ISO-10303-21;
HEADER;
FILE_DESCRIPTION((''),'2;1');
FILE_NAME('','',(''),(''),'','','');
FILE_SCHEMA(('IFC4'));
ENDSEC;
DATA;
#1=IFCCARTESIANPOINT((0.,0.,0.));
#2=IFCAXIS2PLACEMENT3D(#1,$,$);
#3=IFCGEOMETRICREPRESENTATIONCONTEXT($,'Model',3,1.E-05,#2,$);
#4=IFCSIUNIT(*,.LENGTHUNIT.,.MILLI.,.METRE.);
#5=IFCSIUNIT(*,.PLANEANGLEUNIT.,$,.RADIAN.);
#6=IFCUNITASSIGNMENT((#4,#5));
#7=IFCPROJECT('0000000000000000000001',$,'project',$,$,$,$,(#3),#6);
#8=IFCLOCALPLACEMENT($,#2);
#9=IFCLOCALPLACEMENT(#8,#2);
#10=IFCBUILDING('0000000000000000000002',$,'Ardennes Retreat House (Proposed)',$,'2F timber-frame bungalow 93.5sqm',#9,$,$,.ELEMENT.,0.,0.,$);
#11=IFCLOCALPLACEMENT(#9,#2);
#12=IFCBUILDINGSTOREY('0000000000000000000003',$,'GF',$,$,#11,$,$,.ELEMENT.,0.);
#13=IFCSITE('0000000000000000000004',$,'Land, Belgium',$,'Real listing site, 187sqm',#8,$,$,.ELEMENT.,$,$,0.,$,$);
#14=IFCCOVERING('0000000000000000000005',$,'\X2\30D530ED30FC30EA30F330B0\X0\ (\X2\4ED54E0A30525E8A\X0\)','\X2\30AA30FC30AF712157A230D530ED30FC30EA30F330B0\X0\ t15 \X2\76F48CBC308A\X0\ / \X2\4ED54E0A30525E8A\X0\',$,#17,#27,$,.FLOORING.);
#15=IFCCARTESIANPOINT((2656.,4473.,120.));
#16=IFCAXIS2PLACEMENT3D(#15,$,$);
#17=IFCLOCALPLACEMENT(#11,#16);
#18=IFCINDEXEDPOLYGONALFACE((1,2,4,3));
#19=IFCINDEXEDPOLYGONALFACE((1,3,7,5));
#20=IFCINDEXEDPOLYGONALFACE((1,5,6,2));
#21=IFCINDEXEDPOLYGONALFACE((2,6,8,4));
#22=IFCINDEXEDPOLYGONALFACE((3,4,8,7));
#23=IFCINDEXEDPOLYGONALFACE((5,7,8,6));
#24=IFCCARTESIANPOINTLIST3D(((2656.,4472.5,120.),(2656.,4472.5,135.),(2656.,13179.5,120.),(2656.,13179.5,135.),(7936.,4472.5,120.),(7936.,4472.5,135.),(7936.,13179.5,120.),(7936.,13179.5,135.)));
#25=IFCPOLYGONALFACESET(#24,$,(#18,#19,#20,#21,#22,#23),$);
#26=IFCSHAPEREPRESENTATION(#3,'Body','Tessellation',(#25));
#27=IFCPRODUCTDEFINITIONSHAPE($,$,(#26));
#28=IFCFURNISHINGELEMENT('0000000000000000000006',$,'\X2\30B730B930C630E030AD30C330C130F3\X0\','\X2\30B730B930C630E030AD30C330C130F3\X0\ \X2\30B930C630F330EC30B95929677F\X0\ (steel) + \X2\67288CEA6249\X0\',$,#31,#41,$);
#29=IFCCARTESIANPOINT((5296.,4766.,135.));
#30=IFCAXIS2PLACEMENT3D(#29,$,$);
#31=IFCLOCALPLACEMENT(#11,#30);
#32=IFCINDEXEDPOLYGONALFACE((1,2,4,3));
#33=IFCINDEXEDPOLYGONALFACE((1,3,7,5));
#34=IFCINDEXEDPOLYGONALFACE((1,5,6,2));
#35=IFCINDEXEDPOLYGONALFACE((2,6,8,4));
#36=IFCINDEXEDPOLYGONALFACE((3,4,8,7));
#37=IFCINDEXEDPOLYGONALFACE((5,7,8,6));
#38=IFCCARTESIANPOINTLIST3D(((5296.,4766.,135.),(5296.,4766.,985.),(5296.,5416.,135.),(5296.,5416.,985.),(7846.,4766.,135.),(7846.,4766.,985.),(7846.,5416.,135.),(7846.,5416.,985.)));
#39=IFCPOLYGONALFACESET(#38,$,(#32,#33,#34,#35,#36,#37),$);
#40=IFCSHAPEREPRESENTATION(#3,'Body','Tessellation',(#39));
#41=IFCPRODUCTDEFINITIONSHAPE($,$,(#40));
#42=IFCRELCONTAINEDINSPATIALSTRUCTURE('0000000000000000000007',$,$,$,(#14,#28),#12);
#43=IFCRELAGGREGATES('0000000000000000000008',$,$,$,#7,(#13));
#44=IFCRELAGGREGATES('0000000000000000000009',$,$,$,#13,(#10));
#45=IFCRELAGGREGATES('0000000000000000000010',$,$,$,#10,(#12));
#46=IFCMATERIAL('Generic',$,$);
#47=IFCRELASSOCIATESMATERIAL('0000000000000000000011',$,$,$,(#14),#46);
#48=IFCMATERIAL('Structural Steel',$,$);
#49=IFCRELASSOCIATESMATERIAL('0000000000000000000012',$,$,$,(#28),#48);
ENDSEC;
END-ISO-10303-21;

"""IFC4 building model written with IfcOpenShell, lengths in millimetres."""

from ifc_helpers import new_model, si_unit, frame, frame_2d, origin, place, context, project, spatial, rectangle, extrude, material, element, save


model = new_model("IFC4")

# Units and contexts
model_context = context("Model", 3, precision=1e-05, world=origin())
ifc_project = project(units=[si_unit("LENGTHUNIT", "METRE", prefix="MILLI"), si_unit("PLANEANGLEUNIT", "RADIAN")], contexts=[model_context])

# Site, building, storey
site_placement = place(None, origin())
site = spatial("IfcSite", under=ifc_project, at=site_placement, Name="Land, Belgium", ObjectType="Real listing site, 187sqm", CompositionType="ELEMENT", RefElevation=0.0)
building_placement = place(site_placement, origin())
building = spatial("IfcBuilding", under=site, at=building_placement, Name="Ardennes Retreat House (Proposed)", ObjectType="2F timber-frame bungalow 93.5sqm", CompositionType="ELEMENT", ElevationOfRefHeight=0.0, ElevationOfTerrain=0.0)
storey_placement = place(building_placement, origin())
storey = spatial("IfcBuildingStorey", under=building, at=storey_placement, Name="GF", CompositionType="ELEMENT", Elevation=0.0)

# Covering
ifc_material_1 = material(Name="Generic")
covering_placement = place(storey_placement, frame((2656.0, 4473.0, 120.0)))
element("IfcCovering", 1, at=covering_placement, inside=storey, material=ifc_material_1, Name="フローリング (仕上げ床)", Description="オーク無垢フローリング t15 直貼り / 仕上げ床", PredefinedType="FLOORING", context=model_context, shape_type="SweptSolid", body=[
    extrude(rectangle(XDim=5280.0, YDim=8707.0, at=frame_2d((2640.0, 4353.0))), frame((2656.0, 4473.0, 120.0)), (0.0, 0.0, 1.0), 15.0),
])

# Furnishing element
ifc_material_2 = material(Name="Structural Steel")
furnishing_placement = place(storey_placement, frame((5296.0, 4766.0, 135.0)))
element("IfcFurnishingElement", 2, at=furnishing_placement, inside=storey, material=ifc_material_2, Name="システムキッチン", Description="システムキッチン ステンレス天板 (steel) + 木質扉", context=model_context, shape_type="SweptSolid", body=[
    extrude(rectangle(XDim=2550.0, YDim=650.0, at=frame_2d((1275.0, 325.0))), frame((5296.0, 4766.0, 135.0)), (0.0, 0.0, 1.0), 850.0),
])

save(model, "model.ifc")
